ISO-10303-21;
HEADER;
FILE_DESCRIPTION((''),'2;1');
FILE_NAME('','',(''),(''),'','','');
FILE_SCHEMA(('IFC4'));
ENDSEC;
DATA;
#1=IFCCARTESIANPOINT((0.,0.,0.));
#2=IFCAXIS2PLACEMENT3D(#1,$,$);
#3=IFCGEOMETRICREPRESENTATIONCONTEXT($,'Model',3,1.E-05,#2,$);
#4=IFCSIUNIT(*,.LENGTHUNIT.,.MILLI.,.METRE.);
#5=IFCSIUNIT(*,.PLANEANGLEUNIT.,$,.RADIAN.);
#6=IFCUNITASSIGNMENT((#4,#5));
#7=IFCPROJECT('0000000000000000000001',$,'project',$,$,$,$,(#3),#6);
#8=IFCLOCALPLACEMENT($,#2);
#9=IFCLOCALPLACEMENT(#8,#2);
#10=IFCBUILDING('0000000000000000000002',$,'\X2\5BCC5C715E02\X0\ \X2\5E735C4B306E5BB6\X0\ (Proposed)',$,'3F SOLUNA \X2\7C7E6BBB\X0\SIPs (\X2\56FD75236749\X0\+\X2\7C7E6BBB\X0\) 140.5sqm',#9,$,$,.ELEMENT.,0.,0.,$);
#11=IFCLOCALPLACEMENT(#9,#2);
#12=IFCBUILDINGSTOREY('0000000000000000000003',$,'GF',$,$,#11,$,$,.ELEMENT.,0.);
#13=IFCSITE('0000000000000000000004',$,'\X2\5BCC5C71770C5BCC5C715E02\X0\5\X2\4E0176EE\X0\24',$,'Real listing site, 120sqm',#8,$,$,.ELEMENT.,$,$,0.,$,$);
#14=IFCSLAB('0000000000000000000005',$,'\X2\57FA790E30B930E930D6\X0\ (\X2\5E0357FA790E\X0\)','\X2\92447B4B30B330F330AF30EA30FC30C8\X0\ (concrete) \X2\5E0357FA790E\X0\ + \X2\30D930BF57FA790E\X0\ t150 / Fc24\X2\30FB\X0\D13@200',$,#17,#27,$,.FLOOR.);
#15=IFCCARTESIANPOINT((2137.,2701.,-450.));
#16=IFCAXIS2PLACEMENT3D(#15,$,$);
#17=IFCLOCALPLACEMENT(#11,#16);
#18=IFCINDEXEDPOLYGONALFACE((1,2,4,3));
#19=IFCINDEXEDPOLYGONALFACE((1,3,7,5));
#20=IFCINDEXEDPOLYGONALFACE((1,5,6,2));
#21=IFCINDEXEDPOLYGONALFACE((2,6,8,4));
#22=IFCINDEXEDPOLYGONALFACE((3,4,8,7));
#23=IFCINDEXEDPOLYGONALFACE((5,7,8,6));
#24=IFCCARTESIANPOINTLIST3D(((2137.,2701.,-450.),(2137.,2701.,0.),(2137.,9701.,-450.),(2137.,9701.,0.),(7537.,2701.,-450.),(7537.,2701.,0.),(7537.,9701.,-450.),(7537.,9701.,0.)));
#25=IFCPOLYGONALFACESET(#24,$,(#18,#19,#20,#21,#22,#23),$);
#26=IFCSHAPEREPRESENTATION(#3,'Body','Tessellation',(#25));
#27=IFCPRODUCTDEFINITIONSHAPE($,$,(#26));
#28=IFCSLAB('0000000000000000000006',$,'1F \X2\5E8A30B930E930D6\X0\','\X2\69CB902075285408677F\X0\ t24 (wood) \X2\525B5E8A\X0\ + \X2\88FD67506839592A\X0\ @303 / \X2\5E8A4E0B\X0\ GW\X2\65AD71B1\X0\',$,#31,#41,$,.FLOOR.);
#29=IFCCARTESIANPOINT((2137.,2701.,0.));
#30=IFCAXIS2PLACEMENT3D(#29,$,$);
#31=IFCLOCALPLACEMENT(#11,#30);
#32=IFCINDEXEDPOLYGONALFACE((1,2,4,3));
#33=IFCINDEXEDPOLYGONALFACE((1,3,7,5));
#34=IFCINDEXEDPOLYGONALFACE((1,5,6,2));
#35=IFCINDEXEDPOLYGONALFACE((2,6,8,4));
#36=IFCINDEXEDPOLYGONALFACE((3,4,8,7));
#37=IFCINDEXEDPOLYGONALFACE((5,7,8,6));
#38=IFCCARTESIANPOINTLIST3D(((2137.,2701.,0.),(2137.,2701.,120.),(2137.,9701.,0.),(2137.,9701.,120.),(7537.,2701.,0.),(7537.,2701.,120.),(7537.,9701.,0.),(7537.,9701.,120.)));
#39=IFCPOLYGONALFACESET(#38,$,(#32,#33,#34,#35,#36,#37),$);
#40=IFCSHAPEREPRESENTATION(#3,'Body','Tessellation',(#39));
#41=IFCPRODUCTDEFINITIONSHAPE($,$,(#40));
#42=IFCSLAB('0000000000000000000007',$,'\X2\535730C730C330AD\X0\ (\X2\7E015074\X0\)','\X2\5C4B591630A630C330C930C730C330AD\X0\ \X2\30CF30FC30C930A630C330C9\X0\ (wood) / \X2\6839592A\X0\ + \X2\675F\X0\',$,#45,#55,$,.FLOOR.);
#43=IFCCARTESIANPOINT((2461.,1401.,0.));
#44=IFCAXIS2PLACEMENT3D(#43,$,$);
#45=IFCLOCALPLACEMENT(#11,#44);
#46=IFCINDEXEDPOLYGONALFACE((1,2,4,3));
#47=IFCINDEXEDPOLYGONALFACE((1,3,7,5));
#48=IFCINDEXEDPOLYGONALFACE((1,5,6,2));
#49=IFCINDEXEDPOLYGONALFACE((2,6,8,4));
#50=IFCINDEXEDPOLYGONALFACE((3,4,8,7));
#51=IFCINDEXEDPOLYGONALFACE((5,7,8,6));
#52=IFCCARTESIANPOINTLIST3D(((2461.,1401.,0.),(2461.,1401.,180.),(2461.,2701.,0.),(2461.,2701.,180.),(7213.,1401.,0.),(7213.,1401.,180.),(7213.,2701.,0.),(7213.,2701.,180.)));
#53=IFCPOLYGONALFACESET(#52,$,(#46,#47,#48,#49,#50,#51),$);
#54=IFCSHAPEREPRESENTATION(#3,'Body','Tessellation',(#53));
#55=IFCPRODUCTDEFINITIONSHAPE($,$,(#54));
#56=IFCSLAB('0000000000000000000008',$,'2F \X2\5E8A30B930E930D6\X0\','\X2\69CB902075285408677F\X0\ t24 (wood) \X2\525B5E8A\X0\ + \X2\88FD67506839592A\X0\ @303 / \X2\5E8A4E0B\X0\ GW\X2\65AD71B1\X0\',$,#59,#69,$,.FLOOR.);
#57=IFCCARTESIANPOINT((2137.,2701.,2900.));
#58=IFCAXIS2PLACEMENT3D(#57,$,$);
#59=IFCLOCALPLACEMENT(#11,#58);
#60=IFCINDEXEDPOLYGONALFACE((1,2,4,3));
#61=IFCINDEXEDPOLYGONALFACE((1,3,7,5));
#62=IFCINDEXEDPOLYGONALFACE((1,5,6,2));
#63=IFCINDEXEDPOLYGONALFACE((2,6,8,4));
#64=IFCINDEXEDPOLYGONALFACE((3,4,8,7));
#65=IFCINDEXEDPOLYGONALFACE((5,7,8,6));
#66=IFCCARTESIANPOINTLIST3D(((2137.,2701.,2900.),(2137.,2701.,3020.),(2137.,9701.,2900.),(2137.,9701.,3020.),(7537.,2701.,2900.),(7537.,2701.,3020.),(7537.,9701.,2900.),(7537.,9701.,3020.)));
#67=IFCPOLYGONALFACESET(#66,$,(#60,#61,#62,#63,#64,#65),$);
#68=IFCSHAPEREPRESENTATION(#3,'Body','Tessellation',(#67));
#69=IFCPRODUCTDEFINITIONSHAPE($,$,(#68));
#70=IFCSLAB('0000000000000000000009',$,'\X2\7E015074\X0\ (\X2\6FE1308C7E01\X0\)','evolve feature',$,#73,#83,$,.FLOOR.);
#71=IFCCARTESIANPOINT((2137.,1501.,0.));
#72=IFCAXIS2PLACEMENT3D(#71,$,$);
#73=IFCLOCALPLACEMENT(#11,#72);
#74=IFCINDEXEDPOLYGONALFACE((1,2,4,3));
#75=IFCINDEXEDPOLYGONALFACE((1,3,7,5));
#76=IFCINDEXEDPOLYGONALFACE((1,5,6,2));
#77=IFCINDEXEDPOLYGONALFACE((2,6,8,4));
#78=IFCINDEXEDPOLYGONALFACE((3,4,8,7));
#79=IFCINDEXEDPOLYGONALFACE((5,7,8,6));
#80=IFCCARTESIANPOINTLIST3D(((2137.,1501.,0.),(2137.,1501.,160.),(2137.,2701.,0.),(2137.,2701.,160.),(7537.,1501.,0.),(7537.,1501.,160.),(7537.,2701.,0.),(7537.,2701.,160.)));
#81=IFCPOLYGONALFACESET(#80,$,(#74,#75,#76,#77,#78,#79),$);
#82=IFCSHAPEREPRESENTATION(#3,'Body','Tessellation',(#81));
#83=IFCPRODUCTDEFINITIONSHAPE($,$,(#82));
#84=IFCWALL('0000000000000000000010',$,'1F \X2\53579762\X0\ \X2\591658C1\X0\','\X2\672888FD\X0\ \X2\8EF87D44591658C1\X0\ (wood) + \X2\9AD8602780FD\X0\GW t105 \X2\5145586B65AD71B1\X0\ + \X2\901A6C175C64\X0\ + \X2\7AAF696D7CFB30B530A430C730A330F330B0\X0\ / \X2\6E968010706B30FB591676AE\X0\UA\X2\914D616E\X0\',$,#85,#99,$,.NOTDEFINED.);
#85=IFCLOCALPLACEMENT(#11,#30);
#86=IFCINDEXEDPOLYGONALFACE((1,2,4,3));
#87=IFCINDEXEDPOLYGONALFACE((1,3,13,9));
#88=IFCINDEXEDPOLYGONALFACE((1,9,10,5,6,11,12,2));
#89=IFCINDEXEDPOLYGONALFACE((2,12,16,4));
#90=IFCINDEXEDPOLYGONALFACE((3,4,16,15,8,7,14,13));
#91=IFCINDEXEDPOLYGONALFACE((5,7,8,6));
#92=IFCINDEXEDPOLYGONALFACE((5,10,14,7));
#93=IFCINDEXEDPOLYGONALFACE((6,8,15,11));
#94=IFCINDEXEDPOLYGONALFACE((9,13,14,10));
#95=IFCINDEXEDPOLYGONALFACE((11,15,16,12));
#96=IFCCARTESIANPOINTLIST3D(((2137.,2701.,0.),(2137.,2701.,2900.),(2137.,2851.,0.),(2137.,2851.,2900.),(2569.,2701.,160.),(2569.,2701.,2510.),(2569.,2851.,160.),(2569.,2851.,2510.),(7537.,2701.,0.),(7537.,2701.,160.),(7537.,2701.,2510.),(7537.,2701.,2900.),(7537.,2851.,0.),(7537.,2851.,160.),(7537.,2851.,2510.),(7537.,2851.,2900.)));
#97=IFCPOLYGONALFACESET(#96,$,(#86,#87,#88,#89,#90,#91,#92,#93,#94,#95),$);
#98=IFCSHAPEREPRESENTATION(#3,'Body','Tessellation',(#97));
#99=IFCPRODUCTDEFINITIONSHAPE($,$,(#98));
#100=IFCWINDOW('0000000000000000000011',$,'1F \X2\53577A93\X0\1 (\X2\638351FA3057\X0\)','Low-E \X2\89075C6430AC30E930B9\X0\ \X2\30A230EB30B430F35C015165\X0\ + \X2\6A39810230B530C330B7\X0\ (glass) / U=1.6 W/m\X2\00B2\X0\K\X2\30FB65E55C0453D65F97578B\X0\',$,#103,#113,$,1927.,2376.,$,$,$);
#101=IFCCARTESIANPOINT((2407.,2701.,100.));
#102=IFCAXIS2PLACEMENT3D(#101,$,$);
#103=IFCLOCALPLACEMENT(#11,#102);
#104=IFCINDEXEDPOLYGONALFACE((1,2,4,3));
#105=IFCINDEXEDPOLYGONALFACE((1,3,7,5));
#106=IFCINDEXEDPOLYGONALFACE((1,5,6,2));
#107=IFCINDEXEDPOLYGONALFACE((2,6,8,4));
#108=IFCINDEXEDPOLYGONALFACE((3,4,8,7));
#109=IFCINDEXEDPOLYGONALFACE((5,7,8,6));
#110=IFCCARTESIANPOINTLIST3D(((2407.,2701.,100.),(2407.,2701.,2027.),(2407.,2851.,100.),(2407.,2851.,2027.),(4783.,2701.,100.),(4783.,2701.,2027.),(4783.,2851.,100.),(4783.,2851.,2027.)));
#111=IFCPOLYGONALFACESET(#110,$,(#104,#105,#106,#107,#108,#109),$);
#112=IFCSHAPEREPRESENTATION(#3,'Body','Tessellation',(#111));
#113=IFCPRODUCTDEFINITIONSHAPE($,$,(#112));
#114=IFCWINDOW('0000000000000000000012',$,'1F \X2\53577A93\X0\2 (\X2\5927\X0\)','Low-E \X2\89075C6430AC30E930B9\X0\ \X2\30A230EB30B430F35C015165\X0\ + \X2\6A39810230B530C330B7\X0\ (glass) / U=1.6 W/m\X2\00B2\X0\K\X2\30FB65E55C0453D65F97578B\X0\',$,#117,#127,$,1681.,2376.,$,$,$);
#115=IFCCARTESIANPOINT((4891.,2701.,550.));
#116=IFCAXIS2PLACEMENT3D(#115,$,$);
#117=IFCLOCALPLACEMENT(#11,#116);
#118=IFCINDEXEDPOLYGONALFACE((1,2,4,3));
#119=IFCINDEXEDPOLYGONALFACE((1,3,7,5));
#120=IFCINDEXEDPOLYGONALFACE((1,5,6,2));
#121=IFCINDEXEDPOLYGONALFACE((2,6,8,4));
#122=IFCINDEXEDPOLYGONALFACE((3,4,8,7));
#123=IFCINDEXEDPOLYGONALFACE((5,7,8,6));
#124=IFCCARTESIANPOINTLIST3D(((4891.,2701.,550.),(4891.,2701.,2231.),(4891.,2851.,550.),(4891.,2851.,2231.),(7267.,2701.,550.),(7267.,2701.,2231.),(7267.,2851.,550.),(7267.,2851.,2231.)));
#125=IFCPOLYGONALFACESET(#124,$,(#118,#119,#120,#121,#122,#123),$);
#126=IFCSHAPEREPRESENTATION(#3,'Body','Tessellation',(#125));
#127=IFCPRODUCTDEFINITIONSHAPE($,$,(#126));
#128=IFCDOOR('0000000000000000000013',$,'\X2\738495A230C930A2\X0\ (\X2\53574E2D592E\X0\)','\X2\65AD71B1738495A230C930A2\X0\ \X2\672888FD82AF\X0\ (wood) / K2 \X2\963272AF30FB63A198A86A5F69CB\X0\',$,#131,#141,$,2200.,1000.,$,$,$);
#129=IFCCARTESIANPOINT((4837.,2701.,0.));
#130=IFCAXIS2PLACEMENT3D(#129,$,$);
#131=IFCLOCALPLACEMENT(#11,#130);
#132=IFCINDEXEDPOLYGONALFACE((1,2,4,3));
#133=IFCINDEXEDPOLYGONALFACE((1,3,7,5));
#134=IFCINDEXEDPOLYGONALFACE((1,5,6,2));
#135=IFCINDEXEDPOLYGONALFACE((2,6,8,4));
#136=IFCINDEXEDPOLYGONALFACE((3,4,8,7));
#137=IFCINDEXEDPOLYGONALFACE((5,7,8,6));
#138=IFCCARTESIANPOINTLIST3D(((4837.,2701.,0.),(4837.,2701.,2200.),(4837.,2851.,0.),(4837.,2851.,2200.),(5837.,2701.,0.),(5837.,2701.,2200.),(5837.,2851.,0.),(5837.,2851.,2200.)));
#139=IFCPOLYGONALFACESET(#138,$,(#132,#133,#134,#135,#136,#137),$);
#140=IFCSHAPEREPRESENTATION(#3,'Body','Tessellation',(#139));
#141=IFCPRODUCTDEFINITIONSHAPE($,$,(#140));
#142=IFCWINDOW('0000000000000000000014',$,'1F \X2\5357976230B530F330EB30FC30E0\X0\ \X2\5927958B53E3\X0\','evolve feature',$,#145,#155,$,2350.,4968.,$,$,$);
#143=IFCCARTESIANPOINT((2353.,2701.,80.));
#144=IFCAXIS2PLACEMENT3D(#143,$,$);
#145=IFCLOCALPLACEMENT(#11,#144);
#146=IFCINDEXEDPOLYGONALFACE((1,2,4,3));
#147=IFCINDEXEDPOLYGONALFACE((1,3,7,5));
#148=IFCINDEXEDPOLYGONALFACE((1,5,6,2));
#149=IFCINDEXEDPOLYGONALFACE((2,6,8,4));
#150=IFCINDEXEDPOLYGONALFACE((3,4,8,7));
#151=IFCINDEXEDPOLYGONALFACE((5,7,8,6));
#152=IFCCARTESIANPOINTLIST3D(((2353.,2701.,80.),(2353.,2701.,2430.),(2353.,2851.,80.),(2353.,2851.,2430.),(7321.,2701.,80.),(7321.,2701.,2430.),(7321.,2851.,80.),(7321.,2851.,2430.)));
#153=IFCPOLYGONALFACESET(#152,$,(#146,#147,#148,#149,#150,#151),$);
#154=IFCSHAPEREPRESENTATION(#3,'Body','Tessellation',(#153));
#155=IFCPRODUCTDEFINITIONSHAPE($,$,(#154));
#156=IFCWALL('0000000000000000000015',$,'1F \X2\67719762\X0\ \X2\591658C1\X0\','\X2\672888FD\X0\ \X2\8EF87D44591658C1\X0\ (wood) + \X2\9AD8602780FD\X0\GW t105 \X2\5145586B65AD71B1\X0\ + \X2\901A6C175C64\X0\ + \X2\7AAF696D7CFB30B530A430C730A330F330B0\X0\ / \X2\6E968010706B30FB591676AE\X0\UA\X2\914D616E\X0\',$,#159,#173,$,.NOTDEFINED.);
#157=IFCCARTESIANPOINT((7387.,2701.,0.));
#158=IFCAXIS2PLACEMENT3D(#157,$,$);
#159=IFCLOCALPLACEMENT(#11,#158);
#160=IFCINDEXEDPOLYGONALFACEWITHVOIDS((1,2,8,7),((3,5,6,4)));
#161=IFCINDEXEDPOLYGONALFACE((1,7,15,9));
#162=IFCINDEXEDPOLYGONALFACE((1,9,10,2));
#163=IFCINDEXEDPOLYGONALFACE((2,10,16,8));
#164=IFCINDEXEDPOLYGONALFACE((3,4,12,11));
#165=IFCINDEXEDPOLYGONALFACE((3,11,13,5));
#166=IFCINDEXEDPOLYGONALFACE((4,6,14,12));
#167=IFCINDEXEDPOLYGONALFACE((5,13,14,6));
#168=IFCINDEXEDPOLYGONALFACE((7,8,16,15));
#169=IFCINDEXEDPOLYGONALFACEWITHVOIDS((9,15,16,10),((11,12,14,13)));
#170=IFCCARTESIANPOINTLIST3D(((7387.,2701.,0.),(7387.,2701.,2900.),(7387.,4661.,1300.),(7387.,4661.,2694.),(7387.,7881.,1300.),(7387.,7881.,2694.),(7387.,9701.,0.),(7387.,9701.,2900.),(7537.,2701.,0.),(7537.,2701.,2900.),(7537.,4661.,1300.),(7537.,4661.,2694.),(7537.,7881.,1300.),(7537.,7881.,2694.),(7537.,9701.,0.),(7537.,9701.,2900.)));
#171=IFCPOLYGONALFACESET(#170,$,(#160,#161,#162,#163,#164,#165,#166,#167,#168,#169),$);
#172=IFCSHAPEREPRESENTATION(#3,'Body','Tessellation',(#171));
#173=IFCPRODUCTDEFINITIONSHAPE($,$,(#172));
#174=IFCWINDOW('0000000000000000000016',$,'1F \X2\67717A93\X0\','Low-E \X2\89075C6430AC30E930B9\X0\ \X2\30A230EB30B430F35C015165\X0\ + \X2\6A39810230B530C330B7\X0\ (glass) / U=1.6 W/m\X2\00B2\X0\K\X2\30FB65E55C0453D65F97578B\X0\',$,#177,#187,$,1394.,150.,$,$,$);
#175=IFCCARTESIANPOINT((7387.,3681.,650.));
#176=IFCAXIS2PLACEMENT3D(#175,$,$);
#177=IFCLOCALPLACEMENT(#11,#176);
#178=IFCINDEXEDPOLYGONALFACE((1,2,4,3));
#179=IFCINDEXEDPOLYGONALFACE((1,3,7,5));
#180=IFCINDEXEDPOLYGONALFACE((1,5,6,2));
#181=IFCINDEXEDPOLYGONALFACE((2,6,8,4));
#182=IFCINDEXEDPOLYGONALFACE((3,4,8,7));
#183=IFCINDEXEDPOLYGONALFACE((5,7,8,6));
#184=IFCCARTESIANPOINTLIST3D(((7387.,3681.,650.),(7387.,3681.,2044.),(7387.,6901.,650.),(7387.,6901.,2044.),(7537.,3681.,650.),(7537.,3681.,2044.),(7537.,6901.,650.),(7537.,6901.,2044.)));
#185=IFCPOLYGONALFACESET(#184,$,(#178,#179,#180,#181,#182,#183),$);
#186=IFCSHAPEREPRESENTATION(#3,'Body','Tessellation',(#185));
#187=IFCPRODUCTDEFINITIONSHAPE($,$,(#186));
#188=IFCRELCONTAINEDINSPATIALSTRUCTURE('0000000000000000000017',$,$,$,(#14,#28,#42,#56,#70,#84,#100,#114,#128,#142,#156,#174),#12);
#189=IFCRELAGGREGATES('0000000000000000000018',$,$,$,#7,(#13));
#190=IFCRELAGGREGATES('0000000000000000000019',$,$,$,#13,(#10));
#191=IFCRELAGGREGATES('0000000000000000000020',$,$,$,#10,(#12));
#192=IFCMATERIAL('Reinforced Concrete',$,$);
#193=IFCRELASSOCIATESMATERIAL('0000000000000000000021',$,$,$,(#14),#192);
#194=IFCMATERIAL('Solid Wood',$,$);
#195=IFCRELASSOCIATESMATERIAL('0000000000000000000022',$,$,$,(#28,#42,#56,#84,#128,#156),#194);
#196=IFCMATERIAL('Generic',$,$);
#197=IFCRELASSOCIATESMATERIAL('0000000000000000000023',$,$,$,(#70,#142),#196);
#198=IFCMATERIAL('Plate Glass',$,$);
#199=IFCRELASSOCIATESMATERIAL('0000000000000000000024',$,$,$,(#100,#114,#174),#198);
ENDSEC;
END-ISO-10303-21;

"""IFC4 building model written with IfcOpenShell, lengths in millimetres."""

from ifc_helpers import new_model, si_unit, frame, frame_2d, origin, place, context, project, spatial, rectangle, extrude, material, element, fill, save


model = new_model("IFC4")

# Units and contexts
model_context = context("Model", 3, precision=1e-05, world=origin())
ifc_project = project(units=[si_unit("LENGTHUNIT", "METRE", prefix="MILLI"), si_unit("PLANEANGLEUNIT", "RADIAN")], contexts=[model_context])

# Site, building, storey
site_placement = place(None, origin())
site = spatial("IfcSite", under=ifc_project, at=site_placement, Name="富山県富山市5丁目24", ObjectType="Real listing site, 120sqm", CompositionType="ELEMENT", RefElevation=0.0)
building_placement = place(site_placement, origin())
building = spatial("IfcBuilding", under=site, at=building_placement, Name="富山市 平屋の家 (Proposed)", ObjectType="3F SOLUNA 籾殻SIPs (国産杉+籾殻) 140.5sqm", CompositionType="ELEMENT", ElevationOfRefHeight=0.0, ElevationOfTerrain=0.0)
storey_placement = place(building_placement, origin())
storey = spatial("IfcBuildingStorey", under=building, at=storey_placement, Name="GF", CompositionType="ELEMENT", Elevation=0.0)

# Slabs
ifc_material_1 = material(Name="Reinforced Concrete")
slab_1_placement = place(storey_placement, frame((2137.0, 2701.0, -450.0)))
element("IfcSlab", 1, at=slab_1_placement, inside=storey, material=ifc_material_1, Name="基礎スラブ (布基礎)", Description="鉄筋コンクリート (concrete) 布基礎 + ベタ基礎 t150 / Fc24・D13@200", PredefinedType="FLOOR", context=model_context, shape_type="SweptSolid", body=[
    extrude(rectangle(XDim=5400.0, YDim=7000.0, at=frame_2d((2700.0, 3500.0))), frame((2137.0, 2701.0, -450.0)), (0.0, 0.0, 1.0), 450.0),
])
ifc_material_2 = material(Name="Solid Wood")
slab_2_placement = place(storey_placement, frame((2137.0, 2701.0, 0.0)))
element("IfcSlab", 2, at=slab_2_placement, inside=storey, material=ifc_material_2, Name="1F 床スラブ", Description="構造用合板 t24 (wood) 剛床 + 製材根太 @303 / 床下 GW断熱", PredefinedType="FLOOR", context=model_context, shape_type="SweptSolid", body=[
    extrude(rectangle(XDim=5400.0, YDim=7000.0, at=frame_2d((2700.0, 3500.0))), frame((2137.0, 2701.0, 0.0)), (0.0, 0.0, 1.0), 120.0),
])
slab_3_placement = place(storey_placement, frame((2461.0, 1401.0, 0.0)))
element("IfcSlab", 3, at=slab_3_placement, inside=storey, material=ifc_material_2, Name="南デッキ (縁側)", Description="屋外ウッドデッキ ハードウッド (wood) / 根太 + 束", PredefinedType="FLOOR", context=model_context, shape_type="SweptSolid", body=[
    extrude(rectangle(XDim=4752.0, YDim=1300.0, at=frame_2d((2376.0, 650.0))), frame((2461.0, 1401.0, 0.0)), (0.0, 0.0, 1.0), 180.0),
])
slab_4_placement = place(storey_placement, frame((2137.0, 2701.0, 2900.0)))
element("IfcSlab", 4, at=slab_4_placement, inside=storey, material=ifc_material_2, Name="2F 床スラブ", Description="構造用合板 t24 (wood) 剛床 + 製材根太 @303 / 床下 GW断熱", PredefinedType="FLOOR", context=model_context, shape_type="SweptSolid", body=[
    extrude(rectangle(XDim=5400.0, YDim=7000.0, at=frame_2d((2700.0, 3500.0))), frame((2137.0, 2701.0, 2900.0)), (0.0, 0.0, 1.0), 120.0),
])
ifc_material_3 = material(Name="Generic")
slab_5_placement = place(storey_placement, frame((2137.0, 1501.0, 0.0)))
element("IfcSlab", 5, at=slab_5_placement, inside=storey, material=ifc_material_3, Name="縁側 (濡れ縁)", Description="evolve feature", PredefinedType="FLOOR", context=model_context, shape_type="SweptSolid", body=[
    extrude(rectangle(XDim=5400.0, YDim=1200.0, at=frame_2d((2700.0, 600.0))), frame((2137.0, 1501.0, 0.0)), (0.0, 0.0, 1.0), 160.0),
])

# Wall, openings, windows, door
wall_1_placement = place(storey_placement, frame((2137.0, 2701.0, 0.0)))
wall_1 = element("IfcWall", 6, at=wall_1_placement, inside=storey, material=ifc_material_2, Name="1F 南面 外壁", Description="木製 軸組外壁 (wood) + 高性能GW t105 充填断熱 + 通気層 + 窯業系サイディング / 準耐火・外皮UA配慮", PredefinedType="NOTDEFINED", context=model_context, shape_type="SweptSolid", body=[
    extrude(rectangle(XDim=5400.0, YDim=150.0, at=frame_2d((2700.0, 75.0))), frame((2137.0, 2701.0, 0.0)), (0.0, 0.0, 1.0), 2900.0),
])
opening_1_placement = place(storey_placement, frame((2407.0, 2701.0, 100.0)))
opening_1 = element("IfcOpeningElement", 7, at=opening_1_placement, cuts=wall_1, PredefinedType="NOTDEFINED", context=model_context, shape_type="SweptSolid", body=[
    extrude(rectangle(XDim=2376.0, YDim=150.0, at=frame_2d((1188.0, 75.0))), frame((2407.0, 2701.0, 100.0)), (0.0, 0.0, 1.0), 1927.0),
])
opening_2_placement = place(storey_placement, frame((4891.0, 2701.0, 550.0)))
opening_2 = element("IfcOpeningElement", 8, at=opening_2_placement, cuts=wall_1, PredefinedType="NOTDEFINED", context=model_context, shape_type="SweptSolid", body=[
    extrude(rectangle(XDim=2376.0, YDim=150.0, at=frame_2d((1188.0, 75.0))), frame((4891.0, 2701.0, 550.0)), (0.0, 0.0, 1.0), 1681.0),
])
opening_3_placement = place(storey_placement, frame((4837.0, 2701.0, 0.0)))
opening_3 = element("IfcOpeningElement", 9, at=opening_3_placement, cuts=wall_1, PredefinedType="NOTDEFINED", context=model_context, shape_type="SweptSolid", body=[
    extrude(rectangle(XDim=1000.0, YDim=150.0, at=frame_2d((500.0, 75.0))), frame((4837.0, 2701.0, 0.0)), (0.0, 0.0, 1.0), 2200.0),
])
opening_4_placement = place(storey_placement, frame((2353.0, 2701.0, 80.0)))
opening_4 = element("IfcOpeningElement", 10, at=opening_4_placement, cuts=wall_1, PredefinedType="NOTDEFINED", context=model_context, shape_type="SweptSolid", body=[
    extrude(rectangle(XDim=4968.0, YDim=150.0, at=frame_2d((2484.0, 75.0))), frame((2353.0, 2701.0, 80.0)), (0.0, 0.0, 1.0), 2350.0),
])
ifc_material_4 = material(Name="Plate Glass")
window_1_placement = place(storey_placement, frame((2407.0, 2701.0, 100.0)))
window_1 = element("IfcWindow", 11, at=window_1_placement, inside=storey, material=ifc_material_4, Name="1F 南窓1 (掃出し)", Description="Low-E 複層ガラス アルゴン封入 + 樹脂サッシ (glass) / U=1.6 W/m²K・日射取得型", OverallHeight=1927.0, OverallWidth=2376.0, context=model_context, shape_type="SweptSolid", body=[
    extrude(rectangle(XDim=2376.0, YDim=150.0, at=frame_2d((1188.0, 75.0))), frame((2407.0, 2701.0, 100.0)), (0.0, 0.0, 1.0), 1927.0),
])
fill(opening_1, window_1)
window_2_placement = place(storey_placement, frame((4891.0, 2701.0, 550.0)))
window_2 = element("IfcWindow", 12, at=window_2_placement, inside=storey, material=ifc_material_4, Name="1F 南窓2 (大)", Description="Low-E 複層ガラス アルゴン封入 + 樹脂サッシ (glass) / U=1.6 W/m²K・日射取得型", OverallHeight=1681.0, OverallWidth=2376.0, context=model_context, shape_type="SweptSolid", body=[
    extrude(rectangle(XDim=2376.0, YDim=150.0, at=frame_2d((1188.0, 75.0))), frame((4891.0, 2701.0, 550.0)), (0.0, 0.0, 1.0), 1681.0),
])
fill(opening_2, window_2)
door_placement = place(storey_placement, frame((4837.0, 2701.0, 0.0)))
door = element("IfcDoor", 13, at=door_placement, inside=storey, material=ifc_material_2, Name="玄関ドア (南中央)", Description="断熱玄関ドア 木製芯 (wood) / K2 防犯・採風機構", OverallHeight=2200.0, OverallWidth=1000.0, context=model_context, shape_type="SweptSolid", body=[
    extrude(rectangle(XDim=1000.0, YDim=150.0, at=frame_2d((500.0, 75.0))), frame((4837.0, 2701.0, 0.0)), (0.0, 0.0, 1.0), 2200.0),
])
fill(opening_3, door)
window_3_placement = place(storey_placement, frame((2353.0, 2701.0, 80.0)))
window_3 = element("IfcWindow", 14, at=window_3_placement, inside=storey, material=ifc_material_3, Name="1F 南面サンルーム 大開口", Description="evolve feature", OverallHeight=2350.0, OverallWidth=4968.0, context=model_context, shape_type="SweptSolid", body=[
    extrude(rectangle(XDim=4968.0, YDim=150.0, at=frame_2d((2484.0, 75.0))), frame((2353.0, 2701.0, 80.0)), (0.0, 0.0, 1.0), 2350.0),
])
fill(opening_4, window_3)

# Wall, opening, window
wall_2_placement = place(storey_placement, frame((7387.0, 2701.0, 0.0)))
wall_2 = element("IfcWall", 15, at=wall_2_placement, inside=storey, material=ifc_material_2, Name="1F 東面 外壁", Description="木製 軸組外壁 (wood) + 高性能GW t105 充填断熱 + 通気層 + 窯業系サイディング / 準耐火・外皮UA配慮", PredefinedType="NOTDEFINED", context=model_context, shape_type="SweptSolid", body=[
    extrude(rectangle(XDim=150.0, YDim=7000.0, at=frame_2d((75.0, 3500.0))), frame((7387.0, 2701.0, 0.0)), (0.0, 0.0, 1.0), 2900.0),
])
opening_5_placement = place(storey_placement, frame((7387.0, 3681.0, 650.0)))
opening_5 = element("IfcOpeningElement", 16, at=opening_5_placement, cuts=wall_2, PredefinedType="NOTDEFINED", context=model_context, shape_type="SweptSolid", body=[
    extrude(rectangle(XDim=150.0, YDim=3220.0, at=frame_2d((75.0, 1610.0))), frame((7387.0, 3681.0, 650.0)), (0.0, 0.0, 1.0), 1394.0),
])
window_4_placement = place(storey_placement, frame((7387.0, 3681.0, 650.0)))
window_4 = element("IfcWindow", 17, at=window_4_placement, inside=storey, material=ifc_material_4, Name="1F 東窓", Description="Low-E 複層ガラス アルゴン封入 + 樹脂サッシ (glass) / U=1.6 W/m²K・日射取得型", OverallHeight=1394.0, OverallWidth=150.0, context=model_context, shape_type="SweptSolid", body=[
    extrude(rectangle(XDim=150.0, YDim=3220.0, at=frame_2d((75.0, 1610.0))), frame((7387.0, 3681.0, 650.0)), (0.0, 0.0, 1.0), 1394.0),
])
fill(opening_5, window_4)

save(model, "model.ifc")
